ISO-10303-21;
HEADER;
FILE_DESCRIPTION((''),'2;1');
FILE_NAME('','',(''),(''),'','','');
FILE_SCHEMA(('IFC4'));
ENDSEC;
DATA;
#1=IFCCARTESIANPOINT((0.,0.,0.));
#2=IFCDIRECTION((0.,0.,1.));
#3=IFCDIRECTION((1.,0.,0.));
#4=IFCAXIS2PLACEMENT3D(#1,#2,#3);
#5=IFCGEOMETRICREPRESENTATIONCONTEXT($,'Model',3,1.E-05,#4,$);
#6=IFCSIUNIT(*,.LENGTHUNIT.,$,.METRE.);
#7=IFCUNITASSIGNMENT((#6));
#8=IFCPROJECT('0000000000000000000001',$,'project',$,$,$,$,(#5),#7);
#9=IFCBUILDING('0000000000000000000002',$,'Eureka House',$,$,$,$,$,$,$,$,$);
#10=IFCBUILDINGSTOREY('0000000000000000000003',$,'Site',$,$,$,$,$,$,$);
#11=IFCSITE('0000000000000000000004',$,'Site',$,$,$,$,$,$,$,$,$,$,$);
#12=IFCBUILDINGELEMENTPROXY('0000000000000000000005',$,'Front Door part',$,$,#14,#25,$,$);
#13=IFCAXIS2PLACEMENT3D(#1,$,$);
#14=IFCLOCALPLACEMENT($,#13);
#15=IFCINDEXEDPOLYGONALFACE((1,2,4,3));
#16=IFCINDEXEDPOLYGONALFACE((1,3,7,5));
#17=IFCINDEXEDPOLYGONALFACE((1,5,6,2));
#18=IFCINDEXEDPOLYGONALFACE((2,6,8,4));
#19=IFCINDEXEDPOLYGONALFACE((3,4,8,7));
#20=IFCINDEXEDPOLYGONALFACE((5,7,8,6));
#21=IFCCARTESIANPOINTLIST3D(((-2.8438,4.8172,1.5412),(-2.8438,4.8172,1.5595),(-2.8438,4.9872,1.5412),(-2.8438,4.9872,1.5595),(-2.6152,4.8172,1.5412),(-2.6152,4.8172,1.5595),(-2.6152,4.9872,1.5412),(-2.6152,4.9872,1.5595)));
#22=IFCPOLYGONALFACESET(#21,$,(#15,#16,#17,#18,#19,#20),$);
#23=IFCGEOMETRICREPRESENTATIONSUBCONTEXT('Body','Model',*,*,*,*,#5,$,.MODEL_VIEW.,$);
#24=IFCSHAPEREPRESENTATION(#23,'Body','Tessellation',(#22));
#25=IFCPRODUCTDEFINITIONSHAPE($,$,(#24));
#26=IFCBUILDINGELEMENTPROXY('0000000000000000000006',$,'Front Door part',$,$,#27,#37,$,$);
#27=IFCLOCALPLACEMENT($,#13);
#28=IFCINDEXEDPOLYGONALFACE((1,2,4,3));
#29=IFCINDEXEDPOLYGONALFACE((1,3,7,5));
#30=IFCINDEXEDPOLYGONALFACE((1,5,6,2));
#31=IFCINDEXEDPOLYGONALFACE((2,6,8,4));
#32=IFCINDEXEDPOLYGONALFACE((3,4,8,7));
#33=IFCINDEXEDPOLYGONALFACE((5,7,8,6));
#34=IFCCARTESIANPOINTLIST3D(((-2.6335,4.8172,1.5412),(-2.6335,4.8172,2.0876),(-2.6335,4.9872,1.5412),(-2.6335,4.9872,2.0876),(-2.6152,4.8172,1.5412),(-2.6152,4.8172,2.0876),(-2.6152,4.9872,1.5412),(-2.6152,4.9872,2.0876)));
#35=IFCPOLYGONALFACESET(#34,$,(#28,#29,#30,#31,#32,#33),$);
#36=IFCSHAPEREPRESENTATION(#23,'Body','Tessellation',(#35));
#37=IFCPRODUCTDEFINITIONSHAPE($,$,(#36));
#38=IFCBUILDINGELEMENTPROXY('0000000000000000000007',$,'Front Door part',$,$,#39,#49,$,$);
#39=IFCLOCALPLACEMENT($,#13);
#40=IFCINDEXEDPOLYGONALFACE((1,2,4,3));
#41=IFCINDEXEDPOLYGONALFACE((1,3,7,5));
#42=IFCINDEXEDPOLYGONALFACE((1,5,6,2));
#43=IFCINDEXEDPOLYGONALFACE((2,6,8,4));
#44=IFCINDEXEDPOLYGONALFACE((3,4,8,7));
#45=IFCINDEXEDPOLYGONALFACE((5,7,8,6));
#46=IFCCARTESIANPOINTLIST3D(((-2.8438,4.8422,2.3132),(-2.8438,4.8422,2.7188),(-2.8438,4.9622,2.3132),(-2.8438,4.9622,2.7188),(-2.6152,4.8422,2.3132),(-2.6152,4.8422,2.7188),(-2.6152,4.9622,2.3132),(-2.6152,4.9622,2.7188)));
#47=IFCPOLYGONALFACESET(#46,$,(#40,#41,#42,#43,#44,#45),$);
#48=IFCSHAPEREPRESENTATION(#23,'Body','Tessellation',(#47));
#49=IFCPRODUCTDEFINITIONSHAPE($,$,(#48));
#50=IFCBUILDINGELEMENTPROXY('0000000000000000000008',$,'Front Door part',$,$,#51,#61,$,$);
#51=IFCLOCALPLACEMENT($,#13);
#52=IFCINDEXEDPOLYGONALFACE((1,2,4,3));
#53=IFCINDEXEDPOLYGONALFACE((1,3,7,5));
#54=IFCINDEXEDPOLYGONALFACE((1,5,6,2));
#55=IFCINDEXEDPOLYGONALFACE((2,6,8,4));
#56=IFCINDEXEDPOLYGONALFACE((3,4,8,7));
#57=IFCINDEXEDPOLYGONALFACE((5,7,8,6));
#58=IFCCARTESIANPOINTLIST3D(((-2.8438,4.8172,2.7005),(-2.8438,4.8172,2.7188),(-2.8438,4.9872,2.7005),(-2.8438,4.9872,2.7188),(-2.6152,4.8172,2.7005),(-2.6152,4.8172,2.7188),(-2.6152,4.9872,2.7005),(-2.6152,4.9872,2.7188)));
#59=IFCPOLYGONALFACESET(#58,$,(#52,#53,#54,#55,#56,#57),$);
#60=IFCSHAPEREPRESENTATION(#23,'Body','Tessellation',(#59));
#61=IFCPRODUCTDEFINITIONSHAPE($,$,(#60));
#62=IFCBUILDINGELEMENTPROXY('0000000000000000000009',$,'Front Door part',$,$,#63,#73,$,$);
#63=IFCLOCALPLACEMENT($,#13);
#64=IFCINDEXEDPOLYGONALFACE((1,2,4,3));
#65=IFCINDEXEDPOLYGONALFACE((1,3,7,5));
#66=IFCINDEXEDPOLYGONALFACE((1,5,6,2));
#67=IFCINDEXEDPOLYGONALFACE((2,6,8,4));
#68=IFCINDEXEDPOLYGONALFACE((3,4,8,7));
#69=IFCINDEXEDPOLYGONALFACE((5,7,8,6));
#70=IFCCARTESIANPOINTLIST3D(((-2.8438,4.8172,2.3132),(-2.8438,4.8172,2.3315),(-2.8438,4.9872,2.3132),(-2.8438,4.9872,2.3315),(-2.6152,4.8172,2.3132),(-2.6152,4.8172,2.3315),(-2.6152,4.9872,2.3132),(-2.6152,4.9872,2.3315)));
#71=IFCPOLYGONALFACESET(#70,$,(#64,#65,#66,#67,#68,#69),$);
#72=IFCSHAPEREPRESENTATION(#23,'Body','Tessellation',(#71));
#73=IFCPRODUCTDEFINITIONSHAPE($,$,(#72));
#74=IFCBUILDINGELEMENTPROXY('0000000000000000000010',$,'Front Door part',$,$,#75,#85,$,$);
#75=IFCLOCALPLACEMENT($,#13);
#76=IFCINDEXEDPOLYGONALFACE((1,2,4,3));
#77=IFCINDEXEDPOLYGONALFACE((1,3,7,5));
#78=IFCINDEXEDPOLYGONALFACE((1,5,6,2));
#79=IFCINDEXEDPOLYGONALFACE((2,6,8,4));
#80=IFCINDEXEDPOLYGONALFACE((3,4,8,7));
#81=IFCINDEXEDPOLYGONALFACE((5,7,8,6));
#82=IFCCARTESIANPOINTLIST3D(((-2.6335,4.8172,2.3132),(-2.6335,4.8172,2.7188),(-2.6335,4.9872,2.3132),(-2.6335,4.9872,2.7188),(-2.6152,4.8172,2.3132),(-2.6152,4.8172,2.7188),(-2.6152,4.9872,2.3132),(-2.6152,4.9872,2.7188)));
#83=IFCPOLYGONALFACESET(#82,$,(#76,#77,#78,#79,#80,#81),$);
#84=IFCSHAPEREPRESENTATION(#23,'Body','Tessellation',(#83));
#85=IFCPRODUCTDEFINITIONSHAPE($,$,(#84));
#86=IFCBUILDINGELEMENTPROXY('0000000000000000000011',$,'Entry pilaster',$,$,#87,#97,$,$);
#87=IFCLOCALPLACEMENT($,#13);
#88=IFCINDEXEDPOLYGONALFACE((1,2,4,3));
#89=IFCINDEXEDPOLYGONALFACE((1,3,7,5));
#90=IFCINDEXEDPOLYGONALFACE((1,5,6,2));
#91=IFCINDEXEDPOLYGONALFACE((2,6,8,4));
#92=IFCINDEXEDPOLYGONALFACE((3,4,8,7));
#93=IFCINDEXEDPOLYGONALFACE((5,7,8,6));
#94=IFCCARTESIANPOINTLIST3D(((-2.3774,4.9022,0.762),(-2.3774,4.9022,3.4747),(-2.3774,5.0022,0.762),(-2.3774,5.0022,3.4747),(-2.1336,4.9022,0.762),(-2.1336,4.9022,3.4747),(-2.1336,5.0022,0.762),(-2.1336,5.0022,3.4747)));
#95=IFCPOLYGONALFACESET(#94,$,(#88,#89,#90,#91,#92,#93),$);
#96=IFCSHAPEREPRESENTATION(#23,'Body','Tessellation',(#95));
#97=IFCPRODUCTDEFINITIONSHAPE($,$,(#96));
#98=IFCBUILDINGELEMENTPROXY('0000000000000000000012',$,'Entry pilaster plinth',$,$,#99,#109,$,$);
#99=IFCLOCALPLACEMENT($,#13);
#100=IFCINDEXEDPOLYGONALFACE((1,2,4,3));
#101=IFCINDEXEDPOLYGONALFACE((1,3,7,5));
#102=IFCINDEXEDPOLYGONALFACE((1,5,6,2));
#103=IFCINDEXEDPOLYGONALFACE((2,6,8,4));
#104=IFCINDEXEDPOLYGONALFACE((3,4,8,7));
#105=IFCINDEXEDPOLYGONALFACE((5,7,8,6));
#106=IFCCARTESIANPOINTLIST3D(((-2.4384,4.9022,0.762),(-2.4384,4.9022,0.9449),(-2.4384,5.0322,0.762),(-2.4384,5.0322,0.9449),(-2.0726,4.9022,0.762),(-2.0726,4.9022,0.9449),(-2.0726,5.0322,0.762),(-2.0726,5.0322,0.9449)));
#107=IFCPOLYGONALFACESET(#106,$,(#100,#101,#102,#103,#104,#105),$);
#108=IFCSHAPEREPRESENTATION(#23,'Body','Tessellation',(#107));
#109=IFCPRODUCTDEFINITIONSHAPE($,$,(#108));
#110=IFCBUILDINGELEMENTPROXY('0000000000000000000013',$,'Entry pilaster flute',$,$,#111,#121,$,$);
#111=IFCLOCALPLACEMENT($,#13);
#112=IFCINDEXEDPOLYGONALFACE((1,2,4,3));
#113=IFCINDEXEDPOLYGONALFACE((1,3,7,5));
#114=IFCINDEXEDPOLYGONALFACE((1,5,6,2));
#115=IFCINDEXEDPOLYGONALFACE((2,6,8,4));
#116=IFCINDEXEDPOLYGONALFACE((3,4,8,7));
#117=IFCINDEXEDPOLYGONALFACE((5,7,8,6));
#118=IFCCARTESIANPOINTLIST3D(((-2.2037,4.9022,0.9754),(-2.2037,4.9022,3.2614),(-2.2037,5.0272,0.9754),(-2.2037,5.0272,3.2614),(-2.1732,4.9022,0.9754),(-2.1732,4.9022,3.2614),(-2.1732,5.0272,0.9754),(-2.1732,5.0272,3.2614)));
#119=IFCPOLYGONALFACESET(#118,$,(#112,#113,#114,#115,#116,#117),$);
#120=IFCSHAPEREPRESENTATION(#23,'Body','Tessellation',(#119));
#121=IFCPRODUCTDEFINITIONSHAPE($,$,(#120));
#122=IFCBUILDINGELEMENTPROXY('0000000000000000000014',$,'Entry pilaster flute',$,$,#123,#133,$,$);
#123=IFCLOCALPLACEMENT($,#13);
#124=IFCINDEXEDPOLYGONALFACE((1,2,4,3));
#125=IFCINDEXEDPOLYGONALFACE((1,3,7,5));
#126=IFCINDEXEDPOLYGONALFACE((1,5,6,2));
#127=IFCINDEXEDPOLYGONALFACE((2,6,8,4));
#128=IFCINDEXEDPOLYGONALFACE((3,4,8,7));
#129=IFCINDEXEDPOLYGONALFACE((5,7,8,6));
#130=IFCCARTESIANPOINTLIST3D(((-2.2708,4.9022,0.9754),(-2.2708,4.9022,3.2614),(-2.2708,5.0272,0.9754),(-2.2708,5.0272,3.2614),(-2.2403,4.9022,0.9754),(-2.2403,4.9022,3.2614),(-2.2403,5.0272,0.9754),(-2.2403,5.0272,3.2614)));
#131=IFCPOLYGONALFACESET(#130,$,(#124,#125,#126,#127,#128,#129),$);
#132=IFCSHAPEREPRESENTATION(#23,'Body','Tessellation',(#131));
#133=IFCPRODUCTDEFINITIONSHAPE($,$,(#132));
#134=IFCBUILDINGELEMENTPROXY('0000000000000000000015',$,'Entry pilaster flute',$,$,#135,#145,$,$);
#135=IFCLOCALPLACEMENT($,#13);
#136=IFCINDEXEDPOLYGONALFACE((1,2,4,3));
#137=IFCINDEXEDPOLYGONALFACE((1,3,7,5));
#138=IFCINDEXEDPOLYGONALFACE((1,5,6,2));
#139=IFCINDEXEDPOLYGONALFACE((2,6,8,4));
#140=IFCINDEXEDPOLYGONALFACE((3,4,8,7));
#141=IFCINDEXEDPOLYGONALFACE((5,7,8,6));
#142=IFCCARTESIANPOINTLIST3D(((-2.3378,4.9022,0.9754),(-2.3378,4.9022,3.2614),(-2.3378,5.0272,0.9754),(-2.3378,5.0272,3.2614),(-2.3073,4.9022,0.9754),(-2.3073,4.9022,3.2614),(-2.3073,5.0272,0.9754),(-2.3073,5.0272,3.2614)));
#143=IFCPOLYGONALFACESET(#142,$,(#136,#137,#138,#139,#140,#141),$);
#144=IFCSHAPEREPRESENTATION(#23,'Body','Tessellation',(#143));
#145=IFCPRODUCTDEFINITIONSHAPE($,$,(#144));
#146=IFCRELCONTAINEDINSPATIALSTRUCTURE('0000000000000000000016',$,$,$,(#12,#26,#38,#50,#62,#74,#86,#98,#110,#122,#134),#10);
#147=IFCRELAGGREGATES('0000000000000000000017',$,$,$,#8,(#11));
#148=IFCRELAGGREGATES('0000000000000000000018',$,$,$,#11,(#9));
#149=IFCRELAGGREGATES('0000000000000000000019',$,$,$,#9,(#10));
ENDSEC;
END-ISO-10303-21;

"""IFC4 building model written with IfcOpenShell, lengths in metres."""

from ifc_helpers import new_model, si_unit, frame, origin, origin_with_axes, origin_2d, place, context, subcontext, project, spatial, rectangle, extrude, element, save


model = new_model("IFC4")

# Units and contexts
model_context = context("Model", 3, precision=1e-05, world=origin_with_axes())
body_context = subcontext(model_context, "Body", "Model", "MODEL_VIEW")
ifc_project = project(units=[si_unit("LENGTHUNIT", "METRE")], contexts=[model_context])

# Site, building, storey
site = spatial("IfcSite", under=ifc_project, Name="Site")
building = spatial("IfcBuilding", under=site, Name="Eureka House")
storey = spatial("IfcBuildingStorey", under=building, Name="Site")

# Building element proxies
for number, where, z_axis, x_axis, name in (
    (1, (-2.7295, 4.9022, 1.5412), (0.0, 0.0, 1.0), (1.0, 0.0, 0.0), "Front Door part"),
):
    element("IfcBuildingElementProxy", number, at=place(None, frame(where, z_axis=z_axis, x_axis=x_axis)), inside=storey, Name=name, context=body_context, shape_type="SweptSolid", body=[
        extrude(rectangle(XDim=0.2286, YDim=0.17, at=origin_2d()), origin(), (0.0, 0.0, 1.0), 0.0183),
    ])
proxy_1_placement = place(None, frame((-2.6243, 4.9022, 1.5412), z_axis=(0.0, 0.0, 1.0), x_axis=(1.0, 0.0, 0.0)))
element("IfcBuildingElementProxy", 2, at=proxy_1_placement, inside=storey, Name="Front Door part", context=body_context, shape_type="SweptSolid", body=[
    extrude(rectangle(XDim=0.0183, YDim=0.17, at=origin_2d()), origin(), (0.0, 0.0, 1.0), 0.5464),
])
proxy_2_placement = place(None, frame((-2.7295, 4.9022, 2.3132), z_axis=(0.0, 0.0, 1.0), x_axis=(1.0, 0.0, 0.0)))
element("IfcBuildingElementProxy", 3, at=proxy_2_placement, inside=storey, Name="Front Door part", context=body_context, shape_type="SweptSolid", body=[
    extrude(rectangle(XDim=0.2286, YDim=0.12, at=origin_2d()), origin(), (0.0, 0.0, 1.0), 0.4056),
])
for number, where, z_axis, x_axis, name in (
    (4, (-2.7295, 4.9022, 2.7005), (0.0, 0.0, 1.0), (1.0, 0.0, 0.0), "Front Door part"),
    (5, (-2.7295, 4.9022, 2.3132), (0.0, 0.0, 1.0), (1.0, 0.0, 0.0), "Front Door part"),
):
    element("IfcBuildingElementProxy", number, at=place(None, frame(where, z_axis=z_axis, x_axis=x_axis)), inside=storey, Name=name, context=body_context, shape_type="SweptSolid", body=[
        extrude(rectangle(XDim=0.2286, YDim=0.17, at=origin_2d()), origin(), (0.0, 0.0, 1.0), 0.0183),
    ])
proxy_3_placement = place(None, frame((-2.6243, 4.9022, 2.3132), z_axis=(0.0, 0.0, 1.0), x_axis=(1.0, 0.0, 0.0)))
element("IfcBuildingElementProxy", 6, at=proxy_3_placement, inside=storey, Name="Front Door part", context=body_context, shape_type="SweptSolid", body=[
    extrude(rectangle(XDim=0.0183, YDim=0.17, at=origin_2d()), origin(), (0.0, 0.0, 1.0), 0.4056),
])
proxy_4_placement = place(None, frame((-2.2555, 4.9522, 0.762), z_axis=(0.0, 0.0, 1.0), x_axis=(1.0, 0.0, 0.0)))
element("IfcBuildingElementProxy", 7, at=proxy_4_placement, inside=storey, Name="Entry pilaster", context=body_context, shape_type="SweptSolid", body=[
    extrude(rectangle(XDim=0.2438, YDim=0.1, at=origin_2d()), origin(), (0.0, 0.0, 1.0), 2.7127),
])
proxy_5_placement = place(None, frame((-2.2555, 4.9672, 0.762), z_axis=(0.0, 0.0, 1.0), x_axis=(1.0, 0.0, 0.0)))
element("IfcBuildingElementProxy", 8, at=proxy_5_placement, inside=storey, Name="Entry pilaster plinth", context=body_context, shape_type="SweptSolid", body=[
    extrude(rectangle(XDim=0.3658, YDim=0.13, at=origin_2d()), origin(), (0.0, 0.0, 1.0), 0.1829),
])
for number, where, z_axis, x_axis, name in (
    (9, (-2.1885, 4.9647, 0.9754), (0.0, 0.0, 1.0), (1.0, 0.0, 0.0), "Entry pilaster flute"),
    (10, (-2.2555, 4.9647, 0.9754), (0.0, 0.0, 1.0), (1.0, 0.0, 0.0), "Entry pilaster flute"),
    (11, (-2.3226, 4.9647, 0.9754), (0.0, 0.0, 1.0), (1.0, 0.0, 0.0), "Entry pilaster flute"),
):
    element("IfcBuildingElementProxy", number, at=place(None, frame(where, z_axis=z_axis, x_axis=x_axis)), inside=storey, Name=name, context=body_context, shape_type="SweptSolid", body=[
        extrude(rectangle(XDim=0.0305, YDim=0.125, at=origin_2d()), origin(), (0.0, 0.0, 1.0), 2.286),
    ])

save(model, "model.ifc")
